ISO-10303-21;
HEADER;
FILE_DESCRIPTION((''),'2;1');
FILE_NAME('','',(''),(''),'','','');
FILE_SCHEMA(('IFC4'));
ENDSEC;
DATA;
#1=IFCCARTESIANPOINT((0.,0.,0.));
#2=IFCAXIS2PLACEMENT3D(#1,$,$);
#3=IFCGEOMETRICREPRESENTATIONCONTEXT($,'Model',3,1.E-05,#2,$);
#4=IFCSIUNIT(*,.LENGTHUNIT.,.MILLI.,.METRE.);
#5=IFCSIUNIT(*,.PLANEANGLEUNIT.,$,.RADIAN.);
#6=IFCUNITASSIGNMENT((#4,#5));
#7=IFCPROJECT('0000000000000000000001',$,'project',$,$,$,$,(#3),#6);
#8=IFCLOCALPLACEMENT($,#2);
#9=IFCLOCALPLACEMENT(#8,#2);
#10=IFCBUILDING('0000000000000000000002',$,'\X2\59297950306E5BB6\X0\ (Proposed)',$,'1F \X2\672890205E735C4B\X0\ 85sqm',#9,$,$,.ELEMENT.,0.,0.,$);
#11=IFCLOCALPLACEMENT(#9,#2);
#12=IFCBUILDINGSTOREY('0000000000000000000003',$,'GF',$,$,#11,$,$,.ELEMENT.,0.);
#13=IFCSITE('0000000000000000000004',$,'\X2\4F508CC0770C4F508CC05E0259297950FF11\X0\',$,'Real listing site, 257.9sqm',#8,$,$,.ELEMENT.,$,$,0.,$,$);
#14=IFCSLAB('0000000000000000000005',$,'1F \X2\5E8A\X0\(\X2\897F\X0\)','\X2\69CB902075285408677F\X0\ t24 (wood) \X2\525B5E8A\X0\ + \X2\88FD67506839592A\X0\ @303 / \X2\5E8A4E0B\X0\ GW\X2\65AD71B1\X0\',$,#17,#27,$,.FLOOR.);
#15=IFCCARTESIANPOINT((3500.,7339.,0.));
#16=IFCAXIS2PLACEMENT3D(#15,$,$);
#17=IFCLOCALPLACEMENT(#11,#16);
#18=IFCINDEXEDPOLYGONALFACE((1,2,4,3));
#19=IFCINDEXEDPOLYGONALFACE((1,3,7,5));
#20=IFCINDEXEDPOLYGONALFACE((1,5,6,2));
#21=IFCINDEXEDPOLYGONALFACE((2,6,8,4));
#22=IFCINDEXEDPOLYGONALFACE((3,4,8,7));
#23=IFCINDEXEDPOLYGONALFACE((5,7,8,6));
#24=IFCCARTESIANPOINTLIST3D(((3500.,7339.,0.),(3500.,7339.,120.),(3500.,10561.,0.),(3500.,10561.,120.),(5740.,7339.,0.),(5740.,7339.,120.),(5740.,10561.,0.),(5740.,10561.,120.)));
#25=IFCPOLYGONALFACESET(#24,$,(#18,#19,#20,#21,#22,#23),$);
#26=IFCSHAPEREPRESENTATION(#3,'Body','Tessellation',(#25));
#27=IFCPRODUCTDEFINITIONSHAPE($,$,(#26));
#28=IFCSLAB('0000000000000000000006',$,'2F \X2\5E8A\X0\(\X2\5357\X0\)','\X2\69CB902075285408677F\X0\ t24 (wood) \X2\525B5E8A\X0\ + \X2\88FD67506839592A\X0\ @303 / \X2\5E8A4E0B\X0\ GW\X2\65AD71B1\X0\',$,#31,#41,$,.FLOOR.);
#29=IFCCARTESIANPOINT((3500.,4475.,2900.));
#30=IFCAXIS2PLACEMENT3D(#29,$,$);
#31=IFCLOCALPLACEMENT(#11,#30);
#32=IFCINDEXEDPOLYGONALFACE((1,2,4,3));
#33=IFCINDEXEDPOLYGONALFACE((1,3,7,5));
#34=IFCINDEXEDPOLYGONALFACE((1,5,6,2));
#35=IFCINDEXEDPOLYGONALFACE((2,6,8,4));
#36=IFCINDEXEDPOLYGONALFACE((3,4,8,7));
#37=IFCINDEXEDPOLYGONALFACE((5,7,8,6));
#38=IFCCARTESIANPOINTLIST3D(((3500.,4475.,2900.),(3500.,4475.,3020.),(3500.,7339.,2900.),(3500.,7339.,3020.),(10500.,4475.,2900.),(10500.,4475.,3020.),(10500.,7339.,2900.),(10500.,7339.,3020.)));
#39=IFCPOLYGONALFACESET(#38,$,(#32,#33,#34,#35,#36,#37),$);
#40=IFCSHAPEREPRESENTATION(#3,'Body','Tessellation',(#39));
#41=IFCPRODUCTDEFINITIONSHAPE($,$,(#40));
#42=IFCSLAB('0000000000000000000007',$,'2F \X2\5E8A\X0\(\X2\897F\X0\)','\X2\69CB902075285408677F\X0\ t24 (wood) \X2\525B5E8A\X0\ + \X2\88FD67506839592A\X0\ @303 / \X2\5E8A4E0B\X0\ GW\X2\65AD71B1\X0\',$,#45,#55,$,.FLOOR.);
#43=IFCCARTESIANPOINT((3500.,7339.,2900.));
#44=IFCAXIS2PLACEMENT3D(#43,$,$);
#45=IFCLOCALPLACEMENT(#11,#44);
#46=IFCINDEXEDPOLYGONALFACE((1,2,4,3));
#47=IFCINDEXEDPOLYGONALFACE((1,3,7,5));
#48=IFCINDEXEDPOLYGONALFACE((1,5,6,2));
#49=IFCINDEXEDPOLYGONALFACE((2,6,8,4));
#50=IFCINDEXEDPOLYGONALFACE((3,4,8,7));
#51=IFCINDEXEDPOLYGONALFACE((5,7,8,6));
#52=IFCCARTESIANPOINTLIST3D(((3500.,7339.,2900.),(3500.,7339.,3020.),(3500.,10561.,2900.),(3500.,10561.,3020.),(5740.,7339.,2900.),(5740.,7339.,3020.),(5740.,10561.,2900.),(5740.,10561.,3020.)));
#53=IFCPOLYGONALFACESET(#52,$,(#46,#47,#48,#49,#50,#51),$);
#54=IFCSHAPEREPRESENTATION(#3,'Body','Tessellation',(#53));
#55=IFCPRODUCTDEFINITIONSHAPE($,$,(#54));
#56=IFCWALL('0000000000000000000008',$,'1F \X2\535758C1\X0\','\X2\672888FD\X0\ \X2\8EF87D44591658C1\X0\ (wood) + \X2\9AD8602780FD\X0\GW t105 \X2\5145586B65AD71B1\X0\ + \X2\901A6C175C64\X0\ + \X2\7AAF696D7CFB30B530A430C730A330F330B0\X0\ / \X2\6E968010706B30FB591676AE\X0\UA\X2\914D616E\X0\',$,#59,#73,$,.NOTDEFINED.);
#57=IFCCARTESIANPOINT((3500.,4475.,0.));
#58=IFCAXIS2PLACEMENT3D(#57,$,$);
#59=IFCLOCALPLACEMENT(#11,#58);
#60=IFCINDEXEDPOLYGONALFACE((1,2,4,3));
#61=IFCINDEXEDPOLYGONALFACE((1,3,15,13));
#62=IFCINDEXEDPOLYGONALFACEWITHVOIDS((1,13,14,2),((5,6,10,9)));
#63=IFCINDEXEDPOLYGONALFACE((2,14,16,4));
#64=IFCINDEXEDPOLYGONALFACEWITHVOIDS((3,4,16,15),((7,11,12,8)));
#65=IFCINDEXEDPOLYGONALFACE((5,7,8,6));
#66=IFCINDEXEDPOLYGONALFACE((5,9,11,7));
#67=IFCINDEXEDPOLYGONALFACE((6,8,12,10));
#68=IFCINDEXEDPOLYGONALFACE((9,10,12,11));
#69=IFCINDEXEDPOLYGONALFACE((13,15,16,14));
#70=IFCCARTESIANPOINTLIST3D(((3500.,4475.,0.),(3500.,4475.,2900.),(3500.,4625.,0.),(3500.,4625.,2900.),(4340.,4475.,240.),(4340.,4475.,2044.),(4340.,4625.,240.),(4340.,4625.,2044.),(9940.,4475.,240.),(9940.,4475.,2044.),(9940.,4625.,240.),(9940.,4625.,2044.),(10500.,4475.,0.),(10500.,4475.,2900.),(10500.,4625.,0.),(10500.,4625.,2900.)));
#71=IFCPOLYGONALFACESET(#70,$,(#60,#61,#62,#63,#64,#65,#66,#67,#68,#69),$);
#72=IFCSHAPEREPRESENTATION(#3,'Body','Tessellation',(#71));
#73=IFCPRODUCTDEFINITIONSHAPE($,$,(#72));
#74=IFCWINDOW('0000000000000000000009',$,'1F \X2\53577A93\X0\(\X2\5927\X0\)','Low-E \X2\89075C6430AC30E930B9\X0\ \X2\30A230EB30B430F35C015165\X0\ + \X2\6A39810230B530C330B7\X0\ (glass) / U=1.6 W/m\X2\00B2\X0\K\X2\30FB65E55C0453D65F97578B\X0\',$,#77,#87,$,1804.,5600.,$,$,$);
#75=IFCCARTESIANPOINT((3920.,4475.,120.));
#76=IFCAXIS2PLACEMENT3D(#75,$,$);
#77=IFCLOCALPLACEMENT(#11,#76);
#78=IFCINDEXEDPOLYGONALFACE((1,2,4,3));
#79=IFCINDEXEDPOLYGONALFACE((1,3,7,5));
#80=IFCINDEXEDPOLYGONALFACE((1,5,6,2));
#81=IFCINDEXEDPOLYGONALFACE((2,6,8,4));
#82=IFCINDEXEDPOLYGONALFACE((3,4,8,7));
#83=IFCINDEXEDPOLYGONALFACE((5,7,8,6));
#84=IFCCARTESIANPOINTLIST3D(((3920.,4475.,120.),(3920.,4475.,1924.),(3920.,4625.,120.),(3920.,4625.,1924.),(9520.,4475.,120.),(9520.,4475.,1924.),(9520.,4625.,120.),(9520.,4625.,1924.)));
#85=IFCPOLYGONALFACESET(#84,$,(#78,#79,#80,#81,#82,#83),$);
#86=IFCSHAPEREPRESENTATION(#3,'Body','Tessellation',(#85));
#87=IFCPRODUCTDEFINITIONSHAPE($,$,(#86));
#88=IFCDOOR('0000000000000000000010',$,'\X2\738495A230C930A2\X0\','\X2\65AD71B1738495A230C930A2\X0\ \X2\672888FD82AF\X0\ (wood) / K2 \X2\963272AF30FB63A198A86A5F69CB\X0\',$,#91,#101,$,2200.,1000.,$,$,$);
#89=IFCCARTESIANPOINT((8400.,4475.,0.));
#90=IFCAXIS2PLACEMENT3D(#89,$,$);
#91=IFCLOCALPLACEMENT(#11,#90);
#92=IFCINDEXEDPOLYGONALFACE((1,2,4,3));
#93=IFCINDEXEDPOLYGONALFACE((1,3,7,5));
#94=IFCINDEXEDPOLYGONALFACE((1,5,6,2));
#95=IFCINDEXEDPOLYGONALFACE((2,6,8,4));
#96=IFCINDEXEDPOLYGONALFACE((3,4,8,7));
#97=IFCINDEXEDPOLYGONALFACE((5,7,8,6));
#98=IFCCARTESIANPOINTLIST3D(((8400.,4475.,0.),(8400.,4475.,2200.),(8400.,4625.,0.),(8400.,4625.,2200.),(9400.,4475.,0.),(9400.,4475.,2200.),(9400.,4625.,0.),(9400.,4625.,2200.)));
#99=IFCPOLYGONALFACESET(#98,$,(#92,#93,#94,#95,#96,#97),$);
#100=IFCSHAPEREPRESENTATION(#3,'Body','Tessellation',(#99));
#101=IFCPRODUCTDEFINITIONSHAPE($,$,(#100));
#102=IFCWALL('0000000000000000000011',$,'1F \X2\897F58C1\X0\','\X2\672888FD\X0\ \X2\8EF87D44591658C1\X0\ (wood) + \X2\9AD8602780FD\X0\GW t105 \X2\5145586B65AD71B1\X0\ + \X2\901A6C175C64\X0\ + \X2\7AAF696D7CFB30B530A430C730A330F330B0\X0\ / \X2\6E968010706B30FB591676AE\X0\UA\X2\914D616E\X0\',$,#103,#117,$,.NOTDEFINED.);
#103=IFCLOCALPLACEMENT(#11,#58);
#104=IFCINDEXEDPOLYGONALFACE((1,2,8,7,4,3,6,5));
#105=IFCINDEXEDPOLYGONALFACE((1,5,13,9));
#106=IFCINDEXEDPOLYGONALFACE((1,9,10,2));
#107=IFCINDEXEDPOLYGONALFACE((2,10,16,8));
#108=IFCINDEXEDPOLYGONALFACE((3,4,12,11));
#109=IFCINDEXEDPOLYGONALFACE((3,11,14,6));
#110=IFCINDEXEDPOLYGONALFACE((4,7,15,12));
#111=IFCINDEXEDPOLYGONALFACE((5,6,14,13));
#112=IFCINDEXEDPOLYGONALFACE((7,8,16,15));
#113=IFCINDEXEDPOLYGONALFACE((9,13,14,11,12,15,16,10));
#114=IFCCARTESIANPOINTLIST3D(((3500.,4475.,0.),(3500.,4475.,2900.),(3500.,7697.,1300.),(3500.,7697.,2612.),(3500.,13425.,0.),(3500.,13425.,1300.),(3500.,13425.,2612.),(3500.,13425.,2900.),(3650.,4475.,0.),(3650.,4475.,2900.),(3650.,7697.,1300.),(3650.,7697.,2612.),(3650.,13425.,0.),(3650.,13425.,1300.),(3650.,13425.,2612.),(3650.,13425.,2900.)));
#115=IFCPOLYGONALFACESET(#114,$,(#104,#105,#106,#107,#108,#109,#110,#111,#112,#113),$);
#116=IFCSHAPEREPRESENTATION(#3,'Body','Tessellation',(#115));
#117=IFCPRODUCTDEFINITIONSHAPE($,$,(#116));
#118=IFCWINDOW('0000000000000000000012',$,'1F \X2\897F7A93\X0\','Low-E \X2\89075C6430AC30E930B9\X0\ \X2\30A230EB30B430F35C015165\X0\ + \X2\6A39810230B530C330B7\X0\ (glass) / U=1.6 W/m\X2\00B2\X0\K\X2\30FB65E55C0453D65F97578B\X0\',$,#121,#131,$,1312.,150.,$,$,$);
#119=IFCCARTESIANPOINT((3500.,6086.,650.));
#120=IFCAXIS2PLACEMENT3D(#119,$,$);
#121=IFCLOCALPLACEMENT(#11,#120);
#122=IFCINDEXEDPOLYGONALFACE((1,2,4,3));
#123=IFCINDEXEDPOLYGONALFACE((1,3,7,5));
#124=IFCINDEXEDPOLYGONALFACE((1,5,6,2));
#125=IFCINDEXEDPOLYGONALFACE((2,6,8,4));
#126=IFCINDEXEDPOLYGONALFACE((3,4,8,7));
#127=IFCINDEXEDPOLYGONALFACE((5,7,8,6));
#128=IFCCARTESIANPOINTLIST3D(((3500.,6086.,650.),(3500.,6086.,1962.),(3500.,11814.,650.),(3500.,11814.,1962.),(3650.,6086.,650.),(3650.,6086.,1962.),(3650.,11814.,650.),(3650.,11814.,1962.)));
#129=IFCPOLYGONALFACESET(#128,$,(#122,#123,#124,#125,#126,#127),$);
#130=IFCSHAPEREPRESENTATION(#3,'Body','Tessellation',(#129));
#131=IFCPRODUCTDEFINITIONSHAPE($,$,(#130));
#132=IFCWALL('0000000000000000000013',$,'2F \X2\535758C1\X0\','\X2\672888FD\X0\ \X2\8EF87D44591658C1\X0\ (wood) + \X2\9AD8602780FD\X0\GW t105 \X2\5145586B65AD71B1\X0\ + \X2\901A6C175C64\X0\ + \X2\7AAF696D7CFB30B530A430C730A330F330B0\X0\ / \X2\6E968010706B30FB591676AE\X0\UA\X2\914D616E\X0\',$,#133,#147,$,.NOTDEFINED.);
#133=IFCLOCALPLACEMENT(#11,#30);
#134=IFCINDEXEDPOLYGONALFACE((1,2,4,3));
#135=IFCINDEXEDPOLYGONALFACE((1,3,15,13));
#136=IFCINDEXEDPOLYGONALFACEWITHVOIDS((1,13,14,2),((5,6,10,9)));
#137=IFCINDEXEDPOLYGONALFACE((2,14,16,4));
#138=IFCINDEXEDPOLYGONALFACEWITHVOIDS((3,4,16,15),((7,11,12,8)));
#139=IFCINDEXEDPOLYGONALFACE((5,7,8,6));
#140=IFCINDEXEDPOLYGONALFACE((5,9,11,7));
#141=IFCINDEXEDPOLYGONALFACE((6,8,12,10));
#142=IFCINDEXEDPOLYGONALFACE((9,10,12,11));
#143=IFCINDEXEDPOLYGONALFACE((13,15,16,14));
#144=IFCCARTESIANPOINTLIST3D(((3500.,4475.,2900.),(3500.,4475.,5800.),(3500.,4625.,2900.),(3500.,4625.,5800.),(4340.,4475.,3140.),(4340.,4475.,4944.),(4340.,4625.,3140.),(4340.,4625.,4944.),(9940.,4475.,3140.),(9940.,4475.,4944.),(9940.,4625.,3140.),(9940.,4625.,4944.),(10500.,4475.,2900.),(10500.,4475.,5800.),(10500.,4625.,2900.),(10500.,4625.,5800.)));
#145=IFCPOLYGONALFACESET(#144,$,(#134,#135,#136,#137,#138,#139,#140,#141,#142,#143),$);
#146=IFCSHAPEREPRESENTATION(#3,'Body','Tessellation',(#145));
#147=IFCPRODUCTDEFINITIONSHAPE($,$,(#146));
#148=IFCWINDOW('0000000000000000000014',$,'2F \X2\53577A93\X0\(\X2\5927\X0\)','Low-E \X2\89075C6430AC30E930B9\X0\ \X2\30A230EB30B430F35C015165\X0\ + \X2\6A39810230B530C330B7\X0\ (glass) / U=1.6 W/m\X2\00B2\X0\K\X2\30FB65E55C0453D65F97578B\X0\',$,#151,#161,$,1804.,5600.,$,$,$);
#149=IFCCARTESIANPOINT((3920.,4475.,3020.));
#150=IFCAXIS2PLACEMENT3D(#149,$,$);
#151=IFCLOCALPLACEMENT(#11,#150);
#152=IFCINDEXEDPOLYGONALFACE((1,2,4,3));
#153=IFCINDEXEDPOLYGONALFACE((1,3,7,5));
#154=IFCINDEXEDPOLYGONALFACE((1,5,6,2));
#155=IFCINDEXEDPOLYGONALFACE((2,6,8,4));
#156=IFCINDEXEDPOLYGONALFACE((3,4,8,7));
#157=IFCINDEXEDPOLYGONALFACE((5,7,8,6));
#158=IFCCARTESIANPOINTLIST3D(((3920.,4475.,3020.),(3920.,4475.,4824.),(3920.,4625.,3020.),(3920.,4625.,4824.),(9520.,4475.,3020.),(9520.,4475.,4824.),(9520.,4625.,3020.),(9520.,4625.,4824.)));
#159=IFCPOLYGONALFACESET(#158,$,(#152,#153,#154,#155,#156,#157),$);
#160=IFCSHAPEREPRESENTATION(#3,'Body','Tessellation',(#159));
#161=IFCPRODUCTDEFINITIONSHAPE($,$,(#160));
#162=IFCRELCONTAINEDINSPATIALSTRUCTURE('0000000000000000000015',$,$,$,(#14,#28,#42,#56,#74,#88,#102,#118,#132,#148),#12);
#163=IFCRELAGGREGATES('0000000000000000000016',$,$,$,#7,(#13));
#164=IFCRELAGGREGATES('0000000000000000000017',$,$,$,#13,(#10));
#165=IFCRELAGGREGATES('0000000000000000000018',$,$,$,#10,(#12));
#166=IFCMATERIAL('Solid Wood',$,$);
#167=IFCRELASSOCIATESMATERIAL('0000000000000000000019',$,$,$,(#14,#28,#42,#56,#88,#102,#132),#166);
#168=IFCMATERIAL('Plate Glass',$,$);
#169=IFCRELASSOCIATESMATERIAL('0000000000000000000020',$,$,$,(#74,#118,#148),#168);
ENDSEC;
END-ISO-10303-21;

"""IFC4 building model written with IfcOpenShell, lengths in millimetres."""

from ifc_helpers import new_model, si_unit, frame, frame_2d, origin, place, context, project, spatial, rectangle, extrude, material, element, fill, save


model = new_model("IFC4")

# Units and contexts
model_context = context("Model", 3, precision=1e-05, world=origin())
ifc_project = project(units=[si_unit("LENGTHUNIT", "METRE", prefix="MILLI"), si_unit("PLANEANGLEUNIT", "RADIAN")], contexts=[model_context])

# Site, building, storey
site_placement = place(None, origin())
site = spatial("IfcSite", under=ifc_project, at=site_placement, Name="佐賀県佐賀市天祐１", ObjectType="Real listing site, 257.9sqm", CompositionType="ELEMENT", RefElevation=0.0)
building_placement = place(site_placement, origin())
building = spatial("IfcBuilding", under=site, at=building_placement, Name="天祐の家 (Proposed)", ObjectType="1F 木造平屋 85sqm", CompositionType="ELEMENT", ElevationOfRefHeight=0.0, ElevationOfTerrain=0.0)
storey_placement = place(building_placement, origin())
storey = spatial("IfcBuildingStorey", under=building, at=storey_placement, Name="GF", CompositionType="ELEMENT", Elevation=0.0)

# Slabs
ifc_material_1 = material(Name="Solid Wood")
slab_1_placement = place(storey_placement, frame((3500.0, 7339.0, 0.0)))
element("IfcSlab", 1, at=slab_1_placement, inside=storey, material=ifc_material_1, Name="1F 床(西)", Description="構造用合板 t24 (wood) 剛床 + 製材根太 @303 / 床下 GW断熱", PredefinedType="FLOOR", context=model_context, shape_type="SweptSolid", body=[
    extrude(rectangle(XDim=2240.0, YDim=3222.0, at=frame_2d((1120.0, 1611.0))), frame((3500.0, 7339.0, 0.0)), (0.0, 0.0, 1.0), 120.0),
])
slab_2_placement = place(storey_placement, frame((3500.0, 4475.0, 2900.0)))
element("IfcSlab", 2, at=slab_2_placement, inside=storey, material=ifc_material_1, Name="2F 床(南)", Description="構造用合板 t24 (wood) 剛床 + 製材根太 @303 / 床下 GW断熱", PredefinedType="FLOOR", context=model_context, shape_type="SweptSolid", body=[
    extrude(rectangle(XDim=7000.0, YDim=2864.0, at=frame_2d((3500.0, 1432.0))), frame((3500.0, 4475.0, 2900.0)), (0.0, 0.0, 1.0), 120.0),
])
slab_3_placement = place(storey_placement, frame((3500.0, 7339.0, 2900.0)))
element("IfcSlab", 3, at=slab_3_placement, inside=storey, material=ifc_material_1, Name="2F 床(西)", Description="構造用合板 t24 (wood) 剛床 + 製材根太 @303 / 床下 GW断熱", PredefinedType="FLOOR", context=model_context, shape_type="SweptSolid", body=[
    extrude(rectangle(XDim=2240.0, YDim=3222.0, at=frame_2d((1120.0, 1611.0))), frame((3500.0, 7339.0, 2900.0)), (0.0, 0.0, 1.0), 120.0),
])

# Wall, openings, window, door
wall_1_placement = place(storey_placement, frame((3500.0, 4475.0, 0.0)))
wall_1 = element("IfcWall", 4, at=wall_1_placement, inside=storey, material=ifc_material_1, Name="1F 南壁", Description="木製 軸組外壁 (wood) + 高性能GW t105 充填断熱 + 通気層 + 窯業系サイディング / 準耐火・外皮UA配慮", PredefinedType="NOTDEFINED", context=model_context, shape_type="SweptSolid", body=[
    extrude(rectangle(XDim=7000.0, YDim=150.0, at=frame_2d((3500.0, 75.0))), frame((3500.0, 4475.0, 0.0)), (0.0, 0.0, 1.0), 2900.0),
])
opening_1_placement = place(storey_placement, frame((3920.0, 4475.0, 120.0)))
opening_1 = element("IfcOpeningElement", 5, at=opening_1_placement, cuts=wall_1, PredefinedType="NOTDEFINED", context=model_context, shape_type="SweptSolid", body=[
    extrude(rectangle(XDim=5600.0, YDim=150.0, at=frame_2d((2800.0, 75.0))), frame((3920.0, 4475.0, 120.0)), (0.0, 0.0, 1.0), 1804.0),
])
opening_2_placement = place(storey_placement, frame((8400.0, 4475.0, 0.0)))
opening_2 = element("IfcOpeningElement", 6, at=opening_2_placement, cuts=wall_1, PredefinedType="NOTDEFINED", context=model_context, shape_type="SweptSolid", body=[
    extrude(rectangle(XDim=1000.0, YDim=150.0, at=frame_2d((500.0, 75.0))), frame((8400.0, 4475.0, 0.0)), (0.0, 0.0, 1.0), 2200.0),
])
ifc_material_2 = material(Name="Plate Glass")
window_1_placement = place(storey_placement, frame((3920.0, 4475.0, 120.0)))
window_1 = element("IfcWindow", 7, at=window_1_placement, inside=storey, material=ifc_material_2, Name="1F 南窓(大)", Description="Low-E 複層ガラス アルゴン封入 + 樹脂サッシ (glass) / U=1.6 W/m²K・日射取得型", OverallHeight=1804.0, OverallWidth=5600.0, context=model_context, shape_type="SweptSolid", body=[
    extrude(rectangle(XDim=5600.0, YDim=150.0, at=frame_2d((2800.0, 75.0))), frame((3920.0, 4475.0, 120.0)), (0.0, 0.0, 1.0), 1804.0),
])
fill(opening_1, window_1)
door_placement = place(storey_placement, frame((8400.0, 4475.0, 0.0)))
door = element("IfcDoor", 8, at=door_placement, inside=storey, material=ifc_material_1, Name="玄関ドア", Description="断熱玄関ドア 木製芯 (wood) / K2 防犯・採風機構", OverallHeight=2200.0, OverallWidth=1000.0, context=model_context, shape_type="SweptSolid", body=[
    extrude(rectangle(XDim=1000.0, YDim=150.0, at=frame_2d((500.0, 75.0))), frame((8400.0, 4475.0, 0.0)), (0.0, 0.0, 1.0), 2200.0),
])
fill(opening_2, door)

# Walls, openings, windows
wall_2_placement = place(storey_placement, frame((3500.0, 4475.0, 0.0)))
wall_2 = element("IfcWall", 9, at=wall_2_placement, inside=storey, material=ifc_material_1, Name="1F 西壁", Description="木製 軸組外壁 (wood) + 高性能GW t105 充填断熱 + 通気層 + 窯業系サイディング / 準耐火・外皮UA配慮", PredefinedType="NOTDEFINED", context=model_context, shape_type="SweptSolid", body=[
    extrude(rectangle(XDim=150.0, YDim=8950.0, at=frame_2d((75.0, 4475.0))), frame((3500.0, 4475.0, 0.0)), (0.0, 0.0, 1.0), 2900.0),
])
opening_3_placement = place(storey_placement, frame((3500.0, 6086.0, 650.0)))
opening_3 = element("IfcOpeningElement", 10, at=opening_3_placement, cuts=wall_2, PredefinedType="NOTDEFINED", context=model_context, shape_type="SweptSolid", body=[
    extrude(rectangle(XDim=150.0, YDim=5728.0, at=frame_2d((75.0, 2864.0))), frame((3500.0, 6086.0, 650.0)), (0.0, 0.0, 1.0), 1312.0),
])
window_2_placement = place(storey_placement, frame((3500.0, 6086.0, 650.0)))
window_2 = element("IfcWindow", 11, at=window_2_placement, inside=storey, material=ifc_material_2, Name="1F 西窓", Description="Low-E 複層ガラス アルゴン封入 + 樹脂サッシ (glass) / U=1.6 W/m²K・日射取得型", OverallHeight=1312.0, OverallWidth=150.0, context=model_context, shape_type="SweptSolid", body=[
    extrude(rectangle(XDim=150.0, YDim=5728.0, at=frame_2d((75.0, 2864.0))), frame((3500.0, 6086.0, 650.0)), (0.0, 0.0, 1.0), 1312.0),
])
fill(opening_3, window_2)
wall_3_placement = place(storey_placement, frame((3500.0, 4475.0, 2900.0)))
wall_3 = element("IfcWall", 12, at=wall_3_placement, inside=storey, material=ifc_material_1, Name="2F 南壁", Description="木製 軸組外壁 (wood) + 高性能GW t105 充填断熱 + 通気層 + 窯業系サイディング / 準耐火・外皮UA配慮", PredefinedType="NOTDEFINED", context=model_context, shape_type="SweptSolid", body=[
    extrude(rectangle(XDim=7000.0, YDim=150.0, at=frame_2d((3500.0, 75.0))), frame((3500.0, 4475.0, 2900.0)), (0.0, 0.0, 1.0), 2900.0),
])
opening_4_placement = place(storey_placement, frame((3920.0, 4475.0, 3020.0)))
opening_4 = element("IfcOpeningElement", 13, at=opening_4_placement, cuts=wall_3, PredefinedType="NOTDEFINED", context=model_context, shape_type="SweptSolid", body=[
    extrude(rectangle(XDim=5600.0, YDim=150.0, at=frame_2d((2800.0, 75.0))), frame((3920.0, 4475.0, 3020.0)), (0.0, 0.0, 1.0), 1804.0),
])
window_3_placement = place(storey_placement, frame((3920.0, 4475.0, 3020.0)))
window_3 = element("IfcWindow", 14, at=window_3_placement, inside=storey, material=ifc_material_2, Name="2F 南窓(大)", Description="Low-E 複層ガラス アルゴン封入 + 樹脂サッシ (glass) / U=1.6 W/m²K・日射取得型", OverallHeight=1804.0, OverallWidth=5600.0, context=model_context, shape_type="SweptSolid", body=[
    extrude(rectangle(XDim=5600.0, YDim=150.0, at=frame_2d((2800.0, 75.0))), frame((3920.0, 4475.0, 3020.0)), (0.0, 0.0, 1.0), 1804.0),
])
fill(opening_4, window_3)

save(model, "model.ifc")
